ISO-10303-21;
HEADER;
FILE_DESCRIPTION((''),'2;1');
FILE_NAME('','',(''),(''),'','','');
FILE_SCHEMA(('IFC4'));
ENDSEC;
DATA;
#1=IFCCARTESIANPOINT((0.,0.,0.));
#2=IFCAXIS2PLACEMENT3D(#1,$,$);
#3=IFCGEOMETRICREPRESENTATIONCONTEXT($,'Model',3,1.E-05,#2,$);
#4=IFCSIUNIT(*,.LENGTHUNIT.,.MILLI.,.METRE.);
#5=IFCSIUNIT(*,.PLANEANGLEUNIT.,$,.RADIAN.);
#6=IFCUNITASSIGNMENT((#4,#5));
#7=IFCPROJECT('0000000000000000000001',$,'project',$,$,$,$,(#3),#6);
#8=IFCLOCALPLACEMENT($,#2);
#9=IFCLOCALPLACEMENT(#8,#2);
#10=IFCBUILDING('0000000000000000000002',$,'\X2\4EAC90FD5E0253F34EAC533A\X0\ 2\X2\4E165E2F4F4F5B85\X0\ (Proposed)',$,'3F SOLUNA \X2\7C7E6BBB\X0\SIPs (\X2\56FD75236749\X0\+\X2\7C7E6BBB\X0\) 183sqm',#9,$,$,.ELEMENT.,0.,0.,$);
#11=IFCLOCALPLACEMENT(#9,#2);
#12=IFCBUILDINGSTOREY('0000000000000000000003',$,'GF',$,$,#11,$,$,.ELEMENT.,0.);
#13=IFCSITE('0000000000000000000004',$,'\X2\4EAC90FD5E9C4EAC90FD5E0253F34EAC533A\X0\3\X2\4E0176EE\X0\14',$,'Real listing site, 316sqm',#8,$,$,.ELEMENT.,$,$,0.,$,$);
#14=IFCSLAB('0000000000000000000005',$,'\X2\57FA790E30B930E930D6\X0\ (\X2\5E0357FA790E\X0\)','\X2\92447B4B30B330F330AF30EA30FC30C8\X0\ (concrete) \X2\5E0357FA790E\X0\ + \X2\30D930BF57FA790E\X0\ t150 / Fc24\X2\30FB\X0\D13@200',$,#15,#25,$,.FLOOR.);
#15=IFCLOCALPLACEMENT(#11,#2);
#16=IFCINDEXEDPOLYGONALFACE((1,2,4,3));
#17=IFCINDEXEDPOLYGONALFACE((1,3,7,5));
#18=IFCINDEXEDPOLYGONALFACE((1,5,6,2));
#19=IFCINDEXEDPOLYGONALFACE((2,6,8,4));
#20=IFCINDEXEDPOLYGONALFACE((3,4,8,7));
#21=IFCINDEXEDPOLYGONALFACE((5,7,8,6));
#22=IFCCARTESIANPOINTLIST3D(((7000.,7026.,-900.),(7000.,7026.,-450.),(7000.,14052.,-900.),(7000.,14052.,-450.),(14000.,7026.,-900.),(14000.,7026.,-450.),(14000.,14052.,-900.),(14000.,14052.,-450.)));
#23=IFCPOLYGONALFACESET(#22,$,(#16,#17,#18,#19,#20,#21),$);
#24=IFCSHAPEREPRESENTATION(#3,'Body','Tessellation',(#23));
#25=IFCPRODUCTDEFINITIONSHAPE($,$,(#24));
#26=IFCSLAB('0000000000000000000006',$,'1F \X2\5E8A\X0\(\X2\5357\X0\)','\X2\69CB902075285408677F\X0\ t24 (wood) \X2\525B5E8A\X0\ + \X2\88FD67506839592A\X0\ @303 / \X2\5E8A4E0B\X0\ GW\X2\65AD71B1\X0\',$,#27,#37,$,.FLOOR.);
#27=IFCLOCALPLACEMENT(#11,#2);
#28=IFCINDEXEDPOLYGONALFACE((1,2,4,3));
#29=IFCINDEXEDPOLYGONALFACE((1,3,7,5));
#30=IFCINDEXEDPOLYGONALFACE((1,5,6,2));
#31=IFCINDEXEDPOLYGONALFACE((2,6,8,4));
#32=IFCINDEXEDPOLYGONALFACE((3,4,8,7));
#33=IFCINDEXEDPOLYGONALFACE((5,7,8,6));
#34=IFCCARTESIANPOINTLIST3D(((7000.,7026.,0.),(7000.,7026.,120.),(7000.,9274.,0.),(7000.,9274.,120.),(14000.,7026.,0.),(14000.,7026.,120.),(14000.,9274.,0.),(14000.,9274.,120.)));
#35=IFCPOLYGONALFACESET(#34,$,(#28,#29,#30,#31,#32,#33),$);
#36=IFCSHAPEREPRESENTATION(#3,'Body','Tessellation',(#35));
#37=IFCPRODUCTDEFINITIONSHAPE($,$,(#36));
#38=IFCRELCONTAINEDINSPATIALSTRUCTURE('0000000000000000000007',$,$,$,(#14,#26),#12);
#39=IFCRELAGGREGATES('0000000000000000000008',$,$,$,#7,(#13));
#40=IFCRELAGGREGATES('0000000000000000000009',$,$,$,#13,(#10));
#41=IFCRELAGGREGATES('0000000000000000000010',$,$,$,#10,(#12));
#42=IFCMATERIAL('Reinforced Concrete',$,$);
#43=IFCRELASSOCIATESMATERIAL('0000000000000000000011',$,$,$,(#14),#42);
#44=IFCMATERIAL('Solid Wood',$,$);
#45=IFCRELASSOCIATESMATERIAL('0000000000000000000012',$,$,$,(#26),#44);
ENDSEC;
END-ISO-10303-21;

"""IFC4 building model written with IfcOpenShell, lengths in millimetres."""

from ifc_helpers import new_model, si_unit, frame, frame_2d, origin, place, context, project, spatial, rectangle, extrude, material, element, save


model = new_model("IFC4")

# Units and contexts
model_context = context("Model", 3, precision=1e-05, world=origin())
ifc_project = project(units=[si_unit("LENGTHUNIT", "METRE", prefix="MILLI"), si_unit("PLANEANGLEUNIT", "RADIAN")], contexts=[model_context])

# Site, building, storey
site_placement = place(None, origin())
site = spatial("IfcSite", under=ifc_project, at=site_placement, Name="京都府京都市右京区3丁目14", ObjectType="Real listing site, 316sqm", CompositionType="ELEMENT", RefElevation=0.0)
building_placement = place(site_placement, origin())
building = spatial("IfcBuilding", under=site, at=building_placement, Name="京都市右京区 2世帯住宅 (Proposed)", ObjectType="3F SOLUNA 籾殻SIPs (国産杉+籾殻) 183sqm", CompositionType="ELEMENT", ElevationOfRefHeight=0.0, ElevationOfTerrain=0.0)
storey_placement = place(building_placement, origin())
storey = spatial("IfcBuildingStorey", under=building, at=storey_placement, Name="GF", CompositionType="ELEMENT", Elevation=0.0)

# Slabs
ifc_material_1 = material(Name="Reinforced Concrete")
slab_1_placement = place(storey_placement, frame((3500.0, 3513.0, -450.0)))
element("IfcSlab", 1, at=slab_1_placement, inside=storey, material=ifc_material_1, Name="基礎スラブ (布基礎)", Description="鉄筋コンクリート (concrete) 布基礎 + ベタ基礎 t150 / Fc24・D13@200", PredefinedType="FLOOR", context=model_context, shape_type="SweptSolid", body=[
    extrude(rectangle(XDim=7000.0, YDim=7026.0, at=frame_2d((3500.0, 3513.0))), frame((3500.0, 3513.0, -450.0)), (0.0, 0.0, 1.0), 450.0),
])
ifc_material_2 = material(Name="Solid Wood")
slab_2_placement = place(storey_placement, frame((3500.0, 3513.0, 0.0)))
element("IfcSlab", 2, at=slab_2_placement, inside=storey, material=ifc_material_2, Name="1F 床(南)", Description="構造用合板 t24 (wood) 剛床 + 製材根太 @303 / 床下 GW断熱", PredefinedType="FLOOR", context=model_context, shape_type="SweptSolid", body=[
    extrude(rectangle(XDim=7000.0, YDim=2248.0, at=frame_2d((3500.0, 1124.0))), frame((3500.0, 3513.0, 0.0)), (0.0, 0.0, 1.0), 120.0),
])

save(model, "model.ifc")
